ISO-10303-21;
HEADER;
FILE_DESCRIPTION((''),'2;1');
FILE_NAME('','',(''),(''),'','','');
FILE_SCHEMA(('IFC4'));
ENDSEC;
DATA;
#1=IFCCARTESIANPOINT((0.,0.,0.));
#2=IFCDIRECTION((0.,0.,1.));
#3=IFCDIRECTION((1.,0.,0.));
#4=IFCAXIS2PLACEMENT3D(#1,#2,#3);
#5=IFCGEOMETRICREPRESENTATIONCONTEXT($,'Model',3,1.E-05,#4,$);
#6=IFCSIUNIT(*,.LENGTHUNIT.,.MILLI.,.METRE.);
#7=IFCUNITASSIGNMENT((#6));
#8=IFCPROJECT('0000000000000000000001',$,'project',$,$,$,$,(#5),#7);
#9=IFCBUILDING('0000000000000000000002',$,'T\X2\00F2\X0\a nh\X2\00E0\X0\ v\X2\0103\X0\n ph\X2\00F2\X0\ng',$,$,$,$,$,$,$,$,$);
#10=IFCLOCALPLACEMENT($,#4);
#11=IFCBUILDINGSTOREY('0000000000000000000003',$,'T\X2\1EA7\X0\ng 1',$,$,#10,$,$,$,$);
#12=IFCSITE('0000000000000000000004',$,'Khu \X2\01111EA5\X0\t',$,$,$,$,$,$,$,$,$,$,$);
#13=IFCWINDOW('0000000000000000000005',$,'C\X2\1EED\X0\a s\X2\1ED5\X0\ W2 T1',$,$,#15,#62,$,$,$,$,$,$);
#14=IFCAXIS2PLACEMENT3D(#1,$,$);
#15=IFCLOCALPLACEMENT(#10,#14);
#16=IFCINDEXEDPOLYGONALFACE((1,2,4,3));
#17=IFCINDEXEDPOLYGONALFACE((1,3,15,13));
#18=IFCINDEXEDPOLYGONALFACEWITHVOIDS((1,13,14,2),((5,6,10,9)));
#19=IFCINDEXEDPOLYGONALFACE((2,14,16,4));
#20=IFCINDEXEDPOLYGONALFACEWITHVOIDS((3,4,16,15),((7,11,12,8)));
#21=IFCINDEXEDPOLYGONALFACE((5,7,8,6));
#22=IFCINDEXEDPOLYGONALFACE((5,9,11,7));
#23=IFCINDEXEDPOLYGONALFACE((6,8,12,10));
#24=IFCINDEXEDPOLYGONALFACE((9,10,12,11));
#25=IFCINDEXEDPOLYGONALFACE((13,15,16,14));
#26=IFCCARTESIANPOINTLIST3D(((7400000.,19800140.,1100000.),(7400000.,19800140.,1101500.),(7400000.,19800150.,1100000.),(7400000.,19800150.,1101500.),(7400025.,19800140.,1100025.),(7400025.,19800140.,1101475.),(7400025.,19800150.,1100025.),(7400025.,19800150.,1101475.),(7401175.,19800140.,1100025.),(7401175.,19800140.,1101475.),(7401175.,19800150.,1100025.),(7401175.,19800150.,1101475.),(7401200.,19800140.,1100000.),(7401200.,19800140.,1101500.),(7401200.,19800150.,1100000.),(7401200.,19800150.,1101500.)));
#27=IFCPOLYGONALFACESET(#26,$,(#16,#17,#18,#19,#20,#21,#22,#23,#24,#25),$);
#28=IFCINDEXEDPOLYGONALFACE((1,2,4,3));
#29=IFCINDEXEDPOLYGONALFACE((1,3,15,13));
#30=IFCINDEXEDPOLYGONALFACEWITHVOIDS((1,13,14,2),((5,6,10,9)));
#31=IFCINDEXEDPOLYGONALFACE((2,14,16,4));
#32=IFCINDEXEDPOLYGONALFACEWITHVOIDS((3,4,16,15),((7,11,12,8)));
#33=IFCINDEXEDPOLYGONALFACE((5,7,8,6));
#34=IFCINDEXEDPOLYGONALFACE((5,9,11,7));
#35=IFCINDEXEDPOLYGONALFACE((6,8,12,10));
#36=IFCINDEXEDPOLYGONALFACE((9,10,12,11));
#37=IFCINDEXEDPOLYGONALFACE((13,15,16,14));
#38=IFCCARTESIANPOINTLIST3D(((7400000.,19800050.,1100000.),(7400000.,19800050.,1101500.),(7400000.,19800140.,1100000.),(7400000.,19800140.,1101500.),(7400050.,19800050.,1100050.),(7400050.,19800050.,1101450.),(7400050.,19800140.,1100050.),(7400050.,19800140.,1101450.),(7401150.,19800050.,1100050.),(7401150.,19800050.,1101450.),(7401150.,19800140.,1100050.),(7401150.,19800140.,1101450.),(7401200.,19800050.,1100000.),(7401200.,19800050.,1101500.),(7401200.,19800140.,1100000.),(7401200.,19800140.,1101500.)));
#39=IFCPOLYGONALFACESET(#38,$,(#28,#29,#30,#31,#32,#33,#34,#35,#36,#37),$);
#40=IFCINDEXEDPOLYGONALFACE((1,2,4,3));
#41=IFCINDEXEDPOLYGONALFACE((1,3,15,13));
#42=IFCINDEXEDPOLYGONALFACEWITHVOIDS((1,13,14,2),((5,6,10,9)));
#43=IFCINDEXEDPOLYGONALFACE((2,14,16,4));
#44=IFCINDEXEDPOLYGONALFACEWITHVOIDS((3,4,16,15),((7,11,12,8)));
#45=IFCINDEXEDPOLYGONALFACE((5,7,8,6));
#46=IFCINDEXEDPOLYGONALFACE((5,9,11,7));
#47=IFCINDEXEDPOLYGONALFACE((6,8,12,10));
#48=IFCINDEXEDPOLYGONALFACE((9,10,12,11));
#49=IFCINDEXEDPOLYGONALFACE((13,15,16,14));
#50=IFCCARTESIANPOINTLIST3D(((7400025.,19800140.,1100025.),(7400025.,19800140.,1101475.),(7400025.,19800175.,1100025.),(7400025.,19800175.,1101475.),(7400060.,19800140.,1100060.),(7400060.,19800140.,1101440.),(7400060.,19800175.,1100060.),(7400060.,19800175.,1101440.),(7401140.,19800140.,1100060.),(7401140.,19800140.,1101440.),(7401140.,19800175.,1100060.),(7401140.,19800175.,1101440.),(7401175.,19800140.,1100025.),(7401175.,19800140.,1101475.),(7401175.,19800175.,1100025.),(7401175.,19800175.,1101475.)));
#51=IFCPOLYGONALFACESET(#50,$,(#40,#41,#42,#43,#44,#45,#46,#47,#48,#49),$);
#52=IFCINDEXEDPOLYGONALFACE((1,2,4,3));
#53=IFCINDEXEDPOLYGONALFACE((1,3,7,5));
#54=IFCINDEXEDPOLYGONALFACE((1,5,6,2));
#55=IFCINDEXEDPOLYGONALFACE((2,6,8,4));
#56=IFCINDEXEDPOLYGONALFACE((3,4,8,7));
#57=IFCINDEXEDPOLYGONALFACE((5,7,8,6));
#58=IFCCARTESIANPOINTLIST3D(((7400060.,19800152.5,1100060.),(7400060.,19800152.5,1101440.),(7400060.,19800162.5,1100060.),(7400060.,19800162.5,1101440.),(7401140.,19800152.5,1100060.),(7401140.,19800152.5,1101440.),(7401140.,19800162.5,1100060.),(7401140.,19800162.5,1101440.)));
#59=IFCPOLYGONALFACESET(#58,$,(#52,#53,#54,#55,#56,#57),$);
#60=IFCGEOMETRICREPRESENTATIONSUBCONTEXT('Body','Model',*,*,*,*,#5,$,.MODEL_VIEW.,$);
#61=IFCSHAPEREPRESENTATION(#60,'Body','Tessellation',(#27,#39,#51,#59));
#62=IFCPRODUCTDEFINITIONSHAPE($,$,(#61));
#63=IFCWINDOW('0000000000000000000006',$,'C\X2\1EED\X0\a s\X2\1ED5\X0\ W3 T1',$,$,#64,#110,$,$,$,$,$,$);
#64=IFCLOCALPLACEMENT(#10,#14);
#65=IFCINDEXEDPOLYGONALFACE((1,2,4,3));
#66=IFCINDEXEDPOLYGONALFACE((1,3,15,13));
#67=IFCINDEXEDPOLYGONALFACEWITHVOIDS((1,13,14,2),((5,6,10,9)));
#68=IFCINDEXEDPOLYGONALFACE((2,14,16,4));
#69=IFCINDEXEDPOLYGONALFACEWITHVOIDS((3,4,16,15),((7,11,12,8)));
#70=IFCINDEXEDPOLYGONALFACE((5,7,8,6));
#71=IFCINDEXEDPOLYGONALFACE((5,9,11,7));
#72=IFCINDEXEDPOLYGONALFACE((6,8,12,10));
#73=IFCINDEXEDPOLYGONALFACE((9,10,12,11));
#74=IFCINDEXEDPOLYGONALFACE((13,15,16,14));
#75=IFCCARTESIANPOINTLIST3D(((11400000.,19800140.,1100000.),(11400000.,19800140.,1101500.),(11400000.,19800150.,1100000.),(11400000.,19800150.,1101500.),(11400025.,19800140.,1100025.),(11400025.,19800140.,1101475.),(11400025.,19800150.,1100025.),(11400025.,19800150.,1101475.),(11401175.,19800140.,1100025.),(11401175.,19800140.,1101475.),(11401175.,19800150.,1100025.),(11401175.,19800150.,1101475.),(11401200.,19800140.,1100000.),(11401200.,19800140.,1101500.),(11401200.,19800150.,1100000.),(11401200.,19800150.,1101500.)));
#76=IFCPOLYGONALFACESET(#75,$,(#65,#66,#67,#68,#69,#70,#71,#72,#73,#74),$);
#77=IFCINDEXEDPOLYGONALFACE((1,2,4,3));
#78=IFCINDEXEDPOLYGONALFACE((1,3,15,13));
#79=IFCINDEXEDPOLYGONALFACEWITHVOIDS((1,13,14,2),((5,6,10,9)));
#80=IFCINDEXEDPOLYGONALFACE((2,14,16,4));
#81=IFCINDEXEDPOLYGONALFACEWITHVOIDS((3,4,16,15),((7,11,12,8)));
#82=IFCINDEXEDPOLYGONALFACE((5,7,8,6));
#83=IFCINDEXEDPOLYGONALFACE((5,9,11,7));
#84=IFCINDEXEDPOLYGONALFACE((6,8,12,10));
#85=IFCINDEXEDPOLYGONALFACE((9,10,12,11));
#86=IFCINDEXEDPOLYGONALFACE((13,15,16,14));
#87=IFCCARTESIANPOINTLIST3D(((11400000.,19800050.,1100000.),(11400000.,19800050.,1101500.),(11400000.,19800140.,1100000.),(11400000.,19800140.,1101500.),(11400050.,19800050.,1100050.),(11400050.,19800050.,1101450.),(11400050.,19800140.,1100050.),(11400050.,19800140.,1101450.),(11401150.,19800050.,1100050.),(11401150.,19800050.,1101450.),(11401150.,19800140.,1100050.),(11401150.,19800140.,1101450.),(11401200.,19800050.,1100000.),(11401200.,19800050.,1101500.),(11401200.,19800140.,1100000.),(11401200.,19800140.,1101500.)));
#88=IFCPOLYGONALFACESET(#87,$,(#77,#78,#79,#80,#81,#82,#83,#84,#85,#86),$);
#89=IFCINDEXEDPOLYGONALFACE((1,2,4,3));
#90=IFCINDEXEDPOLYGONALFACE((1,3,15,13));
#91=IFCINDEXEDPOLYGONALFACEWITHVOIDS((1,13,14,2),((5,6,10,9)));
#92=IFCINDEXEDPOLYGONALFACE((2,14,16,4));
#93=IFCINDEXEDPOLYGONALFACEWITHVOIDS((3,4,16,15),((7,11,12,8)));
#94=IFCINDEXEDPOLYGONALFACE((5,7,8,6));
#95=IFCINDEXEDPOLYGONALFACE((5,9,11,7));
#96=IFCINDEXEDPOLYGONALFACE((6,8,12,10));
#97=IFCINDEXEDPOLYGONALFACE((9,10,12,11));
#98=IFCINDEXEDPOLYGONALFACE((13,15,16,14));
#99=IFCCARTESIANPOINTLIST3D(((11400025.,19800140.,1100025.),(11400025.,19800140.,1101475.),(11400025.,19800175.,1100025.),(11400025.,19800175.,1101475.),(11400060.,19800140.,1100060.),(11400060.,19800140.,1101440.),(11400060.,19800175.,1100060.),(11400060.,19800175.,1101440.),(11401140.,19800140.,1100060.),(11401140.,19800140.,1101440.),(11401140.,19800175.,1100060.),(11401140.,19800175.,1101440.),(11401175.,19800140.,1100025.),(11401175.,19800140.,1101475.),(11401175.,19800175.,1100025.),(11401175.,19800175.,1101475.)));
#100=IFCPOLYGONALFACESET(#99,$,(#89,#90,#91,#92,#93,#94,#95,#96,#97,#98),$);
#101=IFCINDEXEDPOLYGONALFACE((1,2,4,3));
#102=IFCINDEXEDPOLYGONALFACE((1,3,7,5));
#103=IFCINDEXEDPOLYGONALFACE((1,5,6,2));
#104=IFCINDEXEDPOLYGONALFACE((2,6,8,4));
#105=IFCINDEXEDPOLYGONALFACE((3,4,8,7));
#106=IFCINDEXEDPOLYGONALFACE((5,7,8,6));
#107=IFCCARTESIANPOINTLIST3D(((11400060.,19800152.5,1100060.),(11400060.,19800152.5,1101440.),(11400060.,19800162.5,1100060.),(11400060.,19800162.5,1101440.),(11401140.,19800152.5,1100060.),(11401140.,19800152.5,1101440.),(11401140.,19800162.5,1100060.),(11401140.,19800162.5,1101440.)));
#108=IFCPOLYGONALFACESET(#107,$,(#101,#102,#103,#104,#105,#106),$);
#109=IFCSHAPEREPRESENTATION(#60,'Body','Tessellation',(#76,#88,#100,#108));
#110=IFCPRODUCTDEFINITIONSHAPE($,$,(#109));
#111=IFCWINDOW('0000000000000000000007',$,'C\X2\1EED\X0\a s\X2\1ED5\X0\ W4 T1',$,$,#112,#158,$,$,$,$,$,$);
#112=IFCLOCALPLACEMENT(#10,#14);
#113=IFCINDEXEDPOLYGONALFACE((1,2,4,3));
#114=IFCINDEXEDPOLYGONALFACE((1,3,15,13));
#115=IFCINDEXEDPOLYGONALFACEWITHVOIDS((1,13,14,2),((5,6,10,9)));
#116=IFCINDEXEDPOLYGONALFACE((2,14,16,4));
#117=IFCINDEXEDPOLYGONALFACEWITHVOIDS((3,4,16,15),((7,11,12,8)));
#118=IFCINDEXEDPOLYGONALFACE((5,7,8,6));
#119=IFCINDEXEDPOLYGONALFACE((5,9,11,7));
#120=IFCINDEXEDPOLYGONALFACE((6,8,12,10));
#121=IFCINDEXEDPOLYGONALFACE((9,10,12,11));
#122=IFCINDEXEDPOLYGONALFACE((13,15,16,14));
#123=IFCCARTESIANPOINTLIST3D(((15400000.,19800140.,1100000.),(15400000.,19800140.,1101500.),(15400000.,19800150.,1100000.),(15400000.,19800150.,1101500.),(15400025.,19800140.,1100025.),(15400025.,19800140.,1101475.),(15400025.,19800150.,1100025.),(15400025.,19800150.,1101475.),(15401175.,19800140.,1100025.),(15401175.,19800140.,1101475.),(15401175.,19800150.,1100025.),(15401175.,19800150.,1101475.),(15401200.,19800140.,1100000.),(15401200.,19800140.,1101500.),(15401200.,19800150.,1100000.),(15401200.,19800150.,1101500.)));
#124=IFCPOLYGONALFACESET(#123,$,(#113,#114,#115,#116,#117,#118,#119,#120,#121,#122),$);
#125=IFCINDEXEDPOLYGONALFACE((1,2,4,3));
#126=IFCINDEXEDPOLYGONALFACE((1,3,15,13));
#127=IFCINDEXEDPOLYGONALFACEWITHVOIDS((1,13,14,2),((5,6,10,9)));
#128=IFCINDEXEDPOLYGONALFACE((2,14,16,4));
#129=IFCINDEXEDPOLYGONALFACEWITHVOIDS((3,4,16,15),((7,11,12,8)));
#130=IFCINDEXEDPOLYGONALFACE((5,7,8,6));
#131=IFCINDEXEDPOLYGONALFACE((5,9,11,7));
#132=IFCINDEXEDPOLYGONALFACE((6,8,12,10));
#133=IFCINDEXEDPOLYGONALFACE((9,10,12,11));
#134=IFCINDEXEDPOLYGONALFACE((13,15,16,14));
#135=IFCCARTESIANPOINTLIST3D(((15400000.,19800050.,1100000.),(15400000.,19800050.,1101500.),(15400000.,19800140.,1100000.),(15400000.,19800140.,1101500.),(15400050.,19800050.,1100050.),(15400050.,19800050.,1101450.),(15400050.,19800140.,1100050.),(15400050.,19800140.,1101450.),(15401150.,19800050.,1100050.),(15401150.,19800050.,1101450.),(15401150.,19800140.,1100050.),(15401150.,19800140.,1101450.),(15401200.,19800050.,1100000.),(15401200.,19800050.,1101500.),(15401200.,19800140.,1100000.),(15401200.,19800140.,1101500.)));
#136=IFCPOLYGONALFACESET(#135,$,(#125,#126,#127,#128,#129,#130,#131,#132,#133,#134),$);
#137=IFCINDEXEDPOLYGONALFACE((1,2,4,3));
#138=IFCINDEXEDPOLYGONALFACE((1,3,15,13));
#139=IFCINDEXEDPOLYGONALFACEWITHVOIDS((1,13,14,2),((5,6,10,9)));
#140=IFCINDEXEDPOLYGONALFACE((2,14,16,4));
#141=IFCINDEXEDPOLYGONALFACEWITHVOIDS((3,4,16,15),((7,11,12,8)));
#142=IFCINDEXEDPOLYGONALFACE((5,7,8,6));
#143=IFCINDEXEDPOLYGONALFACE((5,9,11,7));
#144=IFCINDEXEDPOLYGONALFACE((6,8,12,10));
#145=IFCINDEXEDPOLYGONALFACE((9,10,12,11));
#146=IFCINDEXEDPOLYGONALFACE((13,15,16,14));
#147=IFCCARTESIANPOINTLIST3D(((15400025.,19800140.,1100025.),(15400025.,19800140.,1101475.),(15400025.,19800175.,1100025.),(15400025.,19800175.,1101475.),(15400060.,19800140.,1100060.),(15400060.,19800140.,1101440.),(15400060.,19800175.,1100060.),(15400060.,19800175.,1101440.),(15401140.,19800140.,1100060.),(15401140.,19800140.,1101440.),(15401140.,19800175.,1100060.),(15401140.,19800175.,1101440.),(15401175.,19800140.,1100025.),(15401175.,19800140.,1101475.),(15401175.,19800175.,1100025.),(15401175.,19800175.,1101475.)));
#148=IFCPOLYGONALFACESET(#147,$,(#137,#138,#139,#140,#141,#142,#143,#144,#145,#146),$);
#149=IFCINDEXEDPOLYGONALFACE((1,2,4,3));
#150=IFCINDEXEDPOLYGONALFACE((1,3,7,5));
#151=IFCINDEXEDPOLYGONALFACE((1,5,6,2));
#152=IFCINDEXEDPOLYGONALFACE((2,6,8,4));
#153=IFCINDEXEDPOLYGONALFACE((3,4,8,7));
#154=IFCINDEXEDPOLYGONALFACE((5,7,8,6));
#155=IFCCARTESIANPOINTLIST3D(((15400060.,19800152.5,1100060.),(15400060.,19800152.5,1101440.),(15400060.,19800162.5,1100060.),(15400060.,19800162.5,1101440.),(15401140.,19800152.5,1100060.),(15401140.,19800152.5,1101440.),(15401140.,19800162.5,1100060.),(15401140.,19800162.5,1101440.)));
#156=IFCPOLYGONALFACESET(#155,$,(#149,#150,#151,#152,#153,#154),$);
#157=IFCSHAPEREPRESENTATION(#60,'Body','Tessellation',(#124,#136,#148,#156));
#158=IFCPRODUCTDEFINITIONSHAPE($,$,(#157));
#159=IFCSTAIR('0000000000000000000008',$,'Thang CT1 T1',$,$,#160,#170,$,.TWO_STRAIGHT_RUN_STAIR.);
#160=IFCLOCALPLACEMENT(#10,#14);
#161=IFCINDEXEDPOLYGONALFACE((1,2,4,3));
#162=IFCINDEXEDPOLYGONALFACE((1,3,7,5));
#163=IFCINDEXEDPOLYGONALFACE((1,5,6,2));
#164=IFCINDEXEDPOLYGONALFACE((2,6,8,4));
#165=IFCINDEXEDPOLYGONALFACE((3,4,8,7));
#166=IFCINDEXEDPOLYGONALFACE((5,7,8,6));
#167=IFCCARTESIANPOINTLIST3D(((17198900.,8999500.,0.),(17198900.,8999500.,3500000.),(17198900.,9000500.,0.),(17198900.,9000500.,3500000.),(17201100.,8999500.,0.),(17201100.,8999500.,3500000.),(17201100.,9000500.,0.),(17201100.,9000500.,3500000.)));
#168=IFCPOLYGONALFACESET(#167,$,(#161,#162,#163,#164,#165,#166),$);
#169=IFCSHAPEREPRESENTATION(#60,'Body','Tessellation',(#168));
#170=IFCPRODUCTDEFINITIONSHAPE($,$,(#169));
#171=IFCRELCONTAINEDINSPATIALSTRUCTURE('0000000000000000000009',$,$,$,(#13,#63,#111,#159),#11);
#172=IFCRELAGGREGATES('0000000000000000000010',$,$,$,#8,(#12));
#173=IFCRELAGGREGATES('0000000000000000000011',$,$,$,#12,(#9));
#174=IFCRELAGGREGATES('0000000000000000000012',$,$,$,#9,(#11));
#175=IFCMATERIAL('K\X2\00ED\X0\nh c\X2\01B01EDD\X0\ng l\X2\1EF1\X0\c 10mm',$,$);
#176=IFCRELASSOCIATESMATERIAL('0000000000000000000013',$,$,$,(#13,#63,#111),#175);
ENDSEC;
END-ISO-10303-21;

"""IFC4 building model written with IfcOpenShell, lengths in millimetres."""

from ifc_helpers import new_model, entity, si_unit, frame, origin_with_axes, place, context, subcontext, project, spatial, line, indexed_curve, outline, extrude, material, element, save


model = new_model("IFC4")

# Units and contexts
model_context = context("Model", 3, precision=1e-05, world=origin_with_axes())
body_context = subcontext(model_context, "Body", "Model", "MODEL_VIEW")
ifc_project = project(units=[si_unit("LENGTHUNIT", "METRE", prefix="MILLI")], contexts=[model_context])

# Site, building, storey
site = spatial("IfcSite", under=ifc_project, Name="Khu đất")
building = spatial("IfcBuilding", under=site, Name="Tòa nhà văn phòng")
storey_placement = place(None, origin_with_axes())
storey = spatial("IfcBuildingStorey", under=building, at=storey_placement, Name="Tầng 1")

# Windows
ifc_material_1 = material(Name="Kính cường lực 10mm")
for number, where, z_axis, x_axis, name in (
    (1, (7400000.0, 19800000.0, 1100000.0), (0.0, 0.0, 1.0), (1.0, 0.0, 0.0), "Cửa sổ W2 T1"),
    (2, (11400000.0, 19800000.0, 1100000.0), (0.0, 0.0, 1.0), (1.0, 0.0, 0.0), "Cửa sổ W3 T1"),
    (3, (15400000.0, 19800000.0, 1100000.0), (0.0, 0.0, 1.0), (1.0, 0.0, 0.0), "Cửa sổ W4 T1"),
):
    element("IfcWindow", number, at=place(storey_placement, frame(where, z_axis=z_axis, x_axis=x_axis)), inside=storey, material=ifc_material_1, Name=name, context=body_context, shape_type="SolidModel", body=[
        extrude(outline(indexed_curve([(0.0, 0.0), (1200.0, 0.0), (1200.0, 1500.0), (0.0, 1500.0)], segments=[line(1, 2, 3, 4, 1)]), holes=[indexed_curve([(25.0, 25.0), (1175.0, 25.0), (1175.0, 1475.0), (25.0, 1475.0)], segments=[line(1, 2, 3, 4, 1)])]), frame((0.0, 140.0, 0.0), z_axis=(0.0, -1.0, 0.0), x_axis=(1.0, 0.0, 0.0)), (0.0, 0.0, -1.0), 10.0),
        extrude(outline(indexed_curve([(0.0, 0.0), (1200.0, 0.0), (1200.0, 1500.0), (0.0, 1500.0)], segments=[line(1, 2, 3, 4, 1)]), holes=[indexed_curve([(50.0, 50.0), (1150.0, 50.0), (1150.0, 1450.0), (50.0, 1450.0)], segments=[line(1, 2, 3, 4, 1)])]), frame((0.0, 50.0, 0.0), z_axis=(0.0, -1.0, 0.0), x_axis=(1.0, 0.0, 0.0)), (0.0, 0.0, -1.0), 90.0),
        extrude(outline(indexed_curve([(0.0, 0.0), (1150.0, 0.0), (1150.0, 1450.0), (0.0, 1450.0)], segments=[line(1, 2, 3, 4, 1)]), holes=[indexed_curve([(35.0, 35.0), (1115.0, 35.0), (1115.0, 1415.0), (35.0, 1415.0)], segments=[line(1, 2, 3, 4, 1)])]), frame((25.0, 140.0, 25.0), z_axis=(0.0, -1.0, 0.0), x_axis=(1.0, 0.0, 0.0)), (0.0, 0.0, -1.0), 35.0),
        extrude(outline(indexed_curve([(35.0, 35.0), (1115.0, 35.0), (1115.0, 1415.0), (35.0, 1415.0)], segments=[line(1, 2, 3, 4, 1)])), frame((25.0, 152.5, 25.0), z_axis=(0.0, -1.0, 0.0), x_axis=(1.0, 0.0, 0.0)), (0.0, 0.0, -1.0), 10.0),
    ])

# Stair
stair_placement = place(storey_placement, frame((17200000.0, 9000000.0, 0.0), z_axis=(0.0, 0.0, 1.0), x_axis=(1.0, 0.0, 0.0)))
element("IfcStair", 4, at=stair_placement, inside=storey, Name="Thang CT1 T1", PredefinedType="TWO_STRAIGHT_RUN_STAIR", context=body_context, shape_type="SweptSolid", body=[
    extrude(entity("IfcRectangleProfileDef", None, None, None, 2200.0, 1000.0), origin_with_axes(), (0.0, 0.0, 1.0), 3500000.0),
])

save(model, "model.ifc")
